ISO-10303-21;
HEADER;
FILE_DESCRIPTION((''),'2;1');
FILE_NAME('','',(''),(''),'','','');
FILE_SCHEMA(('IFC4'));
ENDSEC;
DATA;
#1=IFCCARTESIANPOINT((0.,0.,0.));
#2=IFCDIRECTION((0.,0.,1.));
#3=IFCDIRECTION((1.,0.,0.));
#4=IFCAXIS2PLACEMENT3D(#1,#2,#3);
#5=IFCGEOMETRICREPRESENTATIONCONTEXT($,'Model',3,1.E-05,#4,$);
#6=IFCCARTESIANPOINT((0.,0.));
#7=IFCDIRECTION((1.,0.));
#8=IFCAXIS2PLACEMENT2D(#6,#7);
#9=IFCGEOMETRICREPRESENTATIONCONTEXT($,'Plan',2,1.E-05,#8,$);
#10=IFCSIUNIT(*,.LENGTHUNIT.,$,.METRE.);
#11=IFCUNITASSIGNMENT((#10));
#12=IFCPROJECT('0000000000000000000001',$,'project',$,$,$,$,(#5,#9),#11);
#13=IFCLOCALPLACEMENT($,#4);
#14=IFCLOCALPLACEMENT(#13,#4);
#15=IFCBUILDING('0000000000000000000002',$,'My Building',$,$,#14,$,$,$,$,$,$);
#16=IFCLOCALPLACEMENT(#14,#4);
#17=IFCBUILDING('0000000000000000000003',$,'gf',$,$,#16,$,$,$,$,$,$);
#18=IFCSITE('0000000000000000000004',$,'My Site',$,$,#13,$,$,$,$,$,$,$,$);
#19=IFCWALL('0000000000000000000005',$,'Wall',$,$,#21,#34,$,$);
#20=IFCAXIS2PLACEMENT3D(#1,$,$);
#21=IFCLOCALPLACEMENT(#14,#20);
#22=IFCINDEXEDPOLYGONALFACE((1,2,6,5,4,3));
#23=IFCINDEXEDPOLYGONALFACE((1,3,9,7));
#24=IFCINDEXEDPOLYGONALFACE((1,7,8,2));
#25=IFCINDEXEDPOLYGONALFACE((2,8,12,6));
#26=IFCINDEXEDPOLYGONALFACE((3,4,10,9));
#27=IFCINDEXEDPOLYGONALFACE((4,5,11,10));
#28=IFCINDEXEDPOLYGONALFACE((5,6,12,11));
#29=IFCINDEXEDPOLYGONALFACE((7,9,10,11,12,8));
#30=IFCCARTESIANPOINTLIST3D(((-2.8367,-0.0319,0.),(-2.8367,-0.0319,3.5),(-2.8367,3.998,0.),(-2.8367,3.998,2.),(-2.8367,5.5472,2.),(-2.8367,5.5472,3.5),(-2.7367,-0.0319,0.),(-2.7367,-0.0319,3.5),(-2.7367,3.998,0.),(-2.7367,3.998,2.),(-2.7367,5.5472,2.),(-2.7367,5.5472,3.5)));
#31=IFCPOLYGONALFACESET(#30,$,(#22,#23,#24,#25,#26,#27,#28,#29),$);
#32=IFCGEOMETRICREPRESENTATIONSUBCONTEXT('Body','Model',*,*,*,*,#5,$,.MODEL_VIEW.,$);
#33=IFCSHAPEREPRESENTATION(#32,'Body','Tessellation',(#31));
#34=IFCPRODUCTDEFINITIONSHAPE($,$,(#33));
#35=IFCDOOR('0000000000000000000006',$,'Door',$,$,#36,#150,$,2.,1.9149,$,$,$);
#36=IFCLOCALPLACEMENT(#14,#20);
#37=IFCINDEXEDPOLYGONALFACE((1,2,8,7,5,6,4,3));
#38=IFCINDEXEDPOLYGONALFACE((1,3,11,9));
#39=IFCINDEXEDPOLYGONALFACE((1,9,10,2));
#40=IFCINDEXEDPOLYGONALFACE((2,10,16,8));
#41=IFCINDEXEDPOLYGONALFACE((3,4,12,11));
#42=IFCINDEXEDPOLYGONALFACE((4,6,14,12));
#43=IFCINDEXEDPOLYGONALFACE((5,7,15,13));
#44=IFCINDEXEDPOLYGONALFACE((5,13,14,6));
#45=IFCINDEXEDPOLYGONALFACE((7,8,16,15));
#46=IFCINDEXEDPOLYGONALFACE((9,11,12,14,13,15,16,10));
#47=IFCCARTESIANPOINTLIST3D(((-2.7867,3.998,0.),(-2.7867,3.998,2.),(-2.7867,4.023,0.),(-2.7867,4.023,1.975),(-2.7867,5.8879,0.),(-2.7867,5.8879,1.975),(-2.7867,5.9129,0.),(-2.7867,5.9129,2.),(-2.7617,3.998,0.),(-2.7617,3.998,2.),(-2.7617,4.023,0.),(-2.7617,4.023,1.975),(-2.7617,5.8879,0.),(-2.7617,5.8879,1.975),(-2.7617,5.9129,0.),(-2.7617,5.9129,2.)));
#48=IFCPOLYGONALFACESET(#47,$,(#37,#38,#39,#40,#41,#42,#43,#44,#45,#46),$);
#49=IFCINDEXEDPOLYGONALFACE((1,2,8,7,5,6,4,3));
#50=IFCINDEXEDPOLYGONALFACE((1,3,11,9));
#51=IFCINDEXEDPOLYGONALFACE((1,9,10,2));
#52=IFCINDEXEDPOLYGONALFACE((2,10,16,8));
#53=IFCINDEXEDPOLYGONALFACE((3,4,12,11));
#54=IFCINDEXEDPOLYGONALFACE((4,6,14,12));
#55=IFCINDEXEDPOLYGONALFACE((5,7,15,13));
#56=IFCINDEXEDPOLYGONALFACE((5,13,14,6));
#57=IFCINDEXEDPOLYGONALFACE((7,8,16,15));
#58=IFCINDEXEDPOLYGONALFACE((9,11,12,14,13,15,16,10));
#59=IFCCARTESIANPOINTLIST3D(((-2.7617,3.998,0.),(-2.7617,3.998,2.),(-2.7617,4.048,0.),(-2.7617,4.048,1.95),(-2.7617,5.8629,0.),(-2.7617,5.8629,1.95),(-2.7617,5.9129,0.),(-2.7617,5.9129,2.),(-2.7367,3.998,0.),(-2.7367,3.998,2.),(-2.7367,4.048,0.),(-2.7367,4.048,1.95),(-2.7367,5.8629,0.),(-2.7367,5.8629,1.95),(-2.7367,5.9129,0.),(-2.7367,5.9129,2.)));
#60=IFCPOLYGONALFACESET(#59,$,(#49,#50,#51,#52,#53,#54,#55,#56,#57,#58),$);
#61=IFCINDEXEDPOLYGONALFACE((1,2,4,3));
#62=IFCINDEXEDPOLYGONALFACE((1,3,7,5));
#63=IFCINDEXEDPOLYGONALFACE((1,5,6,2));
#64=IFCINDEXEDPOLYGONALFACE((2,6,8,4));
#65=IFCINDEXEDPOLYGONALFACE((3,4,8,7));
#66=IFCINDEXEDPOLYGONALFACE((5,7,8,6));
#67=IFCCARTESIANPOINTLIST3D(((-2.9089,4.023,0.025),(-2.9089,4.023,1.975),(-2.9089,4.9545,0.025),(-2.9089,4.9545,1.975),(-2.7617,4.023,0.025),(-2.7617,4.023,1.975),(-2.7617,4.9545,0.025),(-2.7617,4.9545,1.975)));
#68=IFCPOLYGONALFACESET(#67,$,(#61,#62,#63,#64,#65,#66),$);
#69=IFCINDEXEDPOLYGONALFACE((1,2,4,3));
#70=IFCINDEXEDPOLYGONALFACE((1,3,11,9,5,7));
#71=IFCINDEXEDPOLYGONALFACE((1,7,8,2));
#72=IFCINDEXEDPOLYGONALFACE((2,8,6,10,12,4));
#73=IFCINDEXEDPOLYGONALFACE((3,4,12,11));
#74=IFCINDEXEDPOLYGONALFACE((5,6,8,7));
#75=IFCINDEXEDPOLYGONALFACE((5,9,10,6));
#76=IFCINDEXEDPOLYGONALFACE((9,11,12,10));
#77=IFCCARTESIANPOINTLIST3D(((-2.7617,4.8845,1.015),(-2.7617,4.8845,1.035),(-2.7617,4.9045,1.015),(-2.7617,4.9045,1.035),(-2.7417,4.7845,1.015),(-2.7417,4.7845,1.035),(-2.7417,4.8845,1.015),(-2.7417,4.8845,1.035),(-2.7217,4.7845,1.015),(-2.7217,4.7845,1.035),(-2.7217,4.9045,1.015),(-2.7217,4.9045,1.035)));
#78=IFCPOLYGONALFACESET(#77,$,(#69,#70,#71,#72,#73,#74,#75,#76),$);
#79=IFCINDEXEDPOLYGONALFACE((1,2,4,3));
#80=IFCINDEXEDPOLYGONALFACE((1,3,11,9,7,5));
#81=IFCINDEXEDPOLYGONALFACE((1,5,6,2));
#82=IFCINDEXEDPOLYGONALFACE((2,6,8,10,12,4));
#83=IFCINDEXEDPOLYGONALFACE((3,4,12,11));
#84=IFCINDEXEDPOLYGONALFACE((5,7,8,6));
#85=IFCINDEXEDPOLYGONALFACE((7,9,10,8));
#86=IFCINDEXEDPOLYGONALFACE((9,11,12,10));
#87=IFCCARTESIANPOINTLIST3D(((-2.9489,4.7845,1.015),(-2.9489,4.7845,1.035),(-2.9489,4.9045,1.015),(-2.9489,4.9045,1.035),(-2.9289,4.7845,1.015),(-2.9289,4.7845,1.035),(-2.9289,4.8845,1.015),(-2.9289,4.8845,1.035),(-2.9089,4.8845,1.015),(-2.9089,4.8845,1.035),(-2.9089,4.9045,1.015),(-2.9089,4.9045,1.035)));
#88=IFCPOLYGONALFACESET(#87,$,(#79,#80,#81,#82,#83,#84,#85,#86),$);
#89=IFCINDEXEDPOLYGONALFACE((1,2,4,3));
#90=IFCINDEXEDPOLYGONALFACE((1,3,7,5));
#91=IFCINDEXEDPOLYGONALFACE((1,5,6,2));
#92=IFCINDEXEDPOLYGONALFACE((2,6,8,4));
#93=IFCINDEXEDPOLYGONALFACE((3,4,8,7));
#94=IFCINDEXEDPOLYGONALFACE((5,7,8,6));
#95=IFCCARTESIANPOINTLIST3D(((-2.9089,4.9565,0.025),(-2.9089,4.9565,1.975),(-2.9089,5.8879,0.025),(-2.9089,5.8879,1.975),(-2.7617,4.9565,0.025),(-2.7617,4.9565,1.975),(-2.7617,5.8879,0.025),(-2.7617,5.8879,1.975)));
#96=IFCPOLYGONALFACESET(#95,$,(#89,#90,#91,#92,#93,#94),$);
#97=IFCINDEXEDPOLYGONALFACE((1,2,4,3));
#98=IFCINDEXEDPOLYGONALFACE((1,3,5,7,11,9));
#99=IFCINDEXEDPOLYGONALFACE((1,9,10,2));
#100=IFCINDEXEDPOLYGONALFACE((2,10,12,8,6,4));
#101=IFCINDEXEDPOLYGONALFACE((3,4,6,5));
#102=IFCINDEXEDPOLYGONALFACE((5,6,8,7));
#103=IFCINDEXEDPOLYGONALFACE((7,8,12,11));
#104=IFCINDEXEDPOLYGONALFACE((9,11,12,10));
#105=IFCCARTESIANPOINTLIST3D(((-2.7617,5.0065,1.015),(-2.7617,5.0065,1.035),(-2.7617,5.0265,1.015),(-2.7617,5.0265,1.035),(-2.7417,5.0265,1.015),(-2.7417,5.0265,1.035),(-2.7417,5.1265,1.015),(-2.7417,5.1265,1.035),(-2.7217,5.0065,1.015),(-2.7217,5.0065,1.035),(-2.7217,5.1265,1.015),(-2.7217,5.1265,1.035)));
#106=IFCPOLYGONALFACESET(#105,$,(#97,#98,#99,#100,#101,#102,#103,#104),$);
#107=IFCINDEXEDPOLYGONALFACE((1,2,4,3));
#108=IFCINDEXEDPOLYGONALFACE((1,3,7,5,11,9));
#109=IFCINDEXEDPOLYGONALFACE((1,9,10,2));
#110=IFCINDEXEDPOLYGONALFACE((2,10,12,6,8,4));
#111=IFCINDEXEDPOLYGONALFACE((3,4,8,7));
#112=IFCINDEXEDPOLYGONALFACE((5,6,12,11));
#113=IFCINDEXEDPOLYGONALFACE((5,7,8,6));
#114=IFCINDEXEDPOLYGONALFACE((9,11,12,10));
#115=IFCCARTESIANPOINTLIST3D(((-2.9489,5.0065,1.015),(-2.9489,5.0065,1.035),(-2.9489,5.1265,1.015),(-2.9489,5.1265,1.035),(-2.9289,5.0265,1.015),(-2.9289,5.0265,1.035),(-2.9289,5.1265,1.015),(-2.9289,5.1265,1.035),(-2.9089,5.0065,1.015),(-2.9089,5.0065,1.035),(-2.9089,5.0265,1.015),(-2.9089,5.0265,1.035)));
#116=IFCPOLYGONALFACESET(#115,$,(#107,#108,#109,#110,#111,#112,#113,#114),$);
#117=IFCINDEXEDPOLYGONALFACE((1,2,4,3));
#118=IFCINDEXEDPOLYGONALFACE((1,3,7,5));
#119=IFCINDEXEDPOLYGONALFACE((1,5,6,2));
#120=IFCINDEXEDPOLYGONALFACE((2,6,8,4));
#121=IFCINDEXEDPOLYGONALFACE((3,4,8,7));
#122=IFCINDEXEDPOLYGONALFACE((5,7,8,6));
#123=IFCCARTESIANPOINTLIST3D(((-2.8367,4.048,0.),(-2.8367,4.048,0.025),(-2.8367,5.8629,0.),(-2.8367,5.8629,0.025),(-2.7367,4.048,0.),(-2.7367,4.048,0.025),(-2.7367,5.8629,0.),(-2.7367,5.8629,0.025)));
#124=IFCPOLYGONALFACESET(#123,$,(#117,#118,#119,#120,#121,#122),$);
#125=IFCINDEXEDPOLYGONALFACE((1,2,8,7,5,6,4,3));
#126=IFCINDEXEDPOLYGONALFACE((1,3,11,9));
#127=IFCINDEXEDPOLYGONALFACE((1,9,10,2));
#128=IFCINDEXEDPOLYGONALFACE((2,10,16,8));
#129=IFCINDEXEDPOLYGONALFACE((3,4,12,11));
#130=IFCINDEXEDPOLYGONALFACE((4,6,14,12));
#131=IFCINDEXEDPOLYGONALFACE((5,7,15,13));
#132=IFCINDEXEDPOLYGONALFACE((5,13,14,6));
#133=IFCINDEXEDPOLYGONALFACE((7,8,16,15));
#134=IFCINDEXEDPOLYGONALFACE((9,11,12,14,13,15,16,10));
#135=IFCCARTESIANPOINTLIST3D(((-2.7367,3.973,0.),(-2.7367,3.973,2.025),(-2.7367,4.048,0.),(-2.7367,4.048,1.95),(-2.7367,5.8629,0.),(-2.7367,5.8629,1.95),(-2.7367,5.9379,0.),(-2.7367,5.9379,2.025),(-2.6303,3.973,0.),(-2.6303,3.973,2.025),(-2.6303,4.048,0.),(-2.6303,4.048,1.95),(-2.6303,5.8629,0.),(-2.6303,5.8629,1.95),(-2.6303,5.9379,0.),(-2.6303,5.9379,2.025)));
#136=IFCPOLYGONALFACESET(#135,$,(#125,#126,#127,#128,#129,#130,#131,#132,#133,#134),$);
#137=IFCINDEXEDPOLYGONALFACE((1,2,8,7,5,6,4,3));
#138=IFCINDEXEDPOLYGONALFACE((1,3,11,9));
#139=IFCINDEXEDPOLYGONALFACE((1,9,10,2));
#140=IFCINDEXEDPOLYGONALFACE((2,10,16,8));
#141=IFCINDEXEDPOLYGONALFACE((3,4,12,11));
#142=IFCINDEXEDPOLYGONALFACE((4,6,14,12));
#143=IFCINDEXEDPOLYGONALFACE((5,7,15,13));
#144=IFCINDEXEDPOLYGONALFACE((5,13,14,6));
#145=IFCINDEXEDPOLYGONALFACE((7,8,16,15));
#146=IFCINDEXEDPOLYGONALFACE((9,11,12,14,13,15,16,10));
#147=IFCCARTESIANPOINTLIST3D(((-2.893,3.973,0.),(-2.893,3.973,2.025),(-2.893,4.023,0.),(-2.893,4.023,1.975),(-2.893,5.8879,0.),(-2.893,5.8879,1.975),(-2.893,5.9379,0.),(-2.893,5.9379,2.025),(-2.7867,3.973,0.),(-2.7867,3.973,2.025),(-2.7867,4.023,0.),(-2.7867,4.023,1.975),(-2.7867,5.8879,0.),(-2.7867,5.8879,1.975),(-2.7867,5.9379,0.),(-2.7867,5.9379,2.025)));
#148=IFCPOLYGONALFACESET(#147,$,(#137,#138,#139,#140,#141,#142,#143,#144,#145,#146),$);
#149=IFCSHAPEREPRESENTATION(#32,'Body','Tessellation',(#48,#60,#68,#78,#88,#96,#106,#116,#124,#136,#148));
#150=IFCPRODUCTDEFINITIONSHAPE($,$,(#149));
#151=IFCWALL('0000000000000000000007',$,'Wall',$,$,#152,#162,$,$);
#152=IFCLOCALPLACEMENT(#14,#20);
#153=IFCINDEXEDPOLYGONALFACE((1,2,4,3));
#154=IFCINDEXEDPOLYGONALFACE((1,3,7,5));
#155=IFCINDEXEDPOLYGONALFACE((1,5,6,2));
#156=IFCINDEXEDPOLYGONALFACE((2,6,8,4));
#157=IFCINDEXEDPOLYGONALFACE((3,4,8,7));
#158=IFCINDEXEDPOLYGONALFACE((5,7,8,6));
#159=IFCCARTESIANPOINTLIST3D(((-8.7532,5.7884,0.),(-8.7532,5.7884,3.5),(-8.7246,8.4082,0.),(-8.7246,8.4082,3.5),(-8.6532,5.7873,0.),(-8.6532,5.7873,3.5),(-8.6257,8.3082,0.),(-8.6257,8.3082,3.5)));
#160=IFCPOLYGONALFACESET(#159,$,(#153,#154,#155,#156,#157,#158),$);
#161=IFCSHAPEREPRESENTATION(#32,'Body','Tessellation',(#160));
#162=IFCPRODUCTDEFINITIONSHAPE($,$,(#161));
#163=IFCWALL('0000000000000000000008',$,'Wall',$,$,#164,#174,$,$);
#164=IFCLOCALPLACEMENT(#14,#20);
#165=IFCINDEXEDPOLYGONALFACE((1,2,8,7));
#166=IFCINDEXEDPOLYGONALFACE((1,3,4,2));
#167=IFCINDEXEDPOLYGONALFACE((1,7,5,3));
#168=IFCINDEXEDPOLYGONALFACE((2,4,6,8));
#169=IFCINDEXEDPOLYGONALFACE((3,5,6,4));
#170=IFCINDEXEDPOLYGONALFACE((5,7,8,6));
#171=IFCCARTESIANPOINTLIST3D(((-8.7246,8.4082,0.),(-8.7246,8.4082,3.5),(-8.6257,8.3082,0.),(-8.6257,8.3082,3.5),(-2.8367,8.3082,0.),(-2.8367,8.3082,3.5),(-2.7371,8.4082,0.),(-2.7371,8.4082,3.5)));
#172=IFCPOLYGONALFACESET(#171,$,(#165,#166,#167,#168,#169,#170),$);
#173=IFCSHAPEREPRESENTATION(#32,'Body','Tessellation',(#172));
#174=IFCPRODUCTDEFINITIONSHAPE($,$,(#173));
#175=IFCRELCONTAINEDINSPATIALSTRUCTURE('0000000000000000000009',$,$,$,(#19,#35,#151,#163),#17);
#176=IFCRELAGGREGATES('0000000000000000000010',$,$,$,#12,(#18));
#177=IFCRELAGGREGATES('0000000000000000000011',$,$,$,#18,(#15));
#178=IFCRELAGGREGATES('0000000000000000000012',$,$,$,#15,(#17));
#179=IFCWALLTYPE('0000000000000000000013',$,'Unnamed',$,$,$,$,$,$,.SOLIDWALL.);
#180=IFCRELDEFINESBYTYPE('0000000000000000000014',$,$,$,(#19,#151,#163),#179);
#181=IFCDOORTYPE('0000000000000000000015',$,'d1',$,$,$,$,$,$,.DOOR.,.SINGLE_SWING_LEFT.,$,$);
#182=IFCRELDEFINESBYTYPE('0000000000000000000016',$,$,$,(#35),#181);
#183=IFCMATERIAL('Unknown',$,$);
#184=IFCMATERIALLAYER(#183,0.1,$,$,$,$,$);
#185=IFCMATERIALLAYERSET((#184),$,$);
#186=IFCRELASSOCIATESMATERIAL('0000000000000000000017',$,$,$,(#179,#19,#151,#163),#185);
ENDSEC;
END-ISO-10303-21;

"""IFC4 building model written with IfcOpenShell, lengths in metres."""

from ifc_helpers import new_model, entity, si_unit, frame, origin_with_axes, origin_2d_with_axis, place, context, subcontext, project, spatial, line, indexed_curve, outline, extrude, shape, source, transform, mapped, material, layer, layer_set, layer_usage, type_object, type_shapes, element, fill, save


model = new_model("IFC4")

# Units and contexts
model_context = context("Model", 3, precision=1e-05, world=origin_with_axes())
plan_context = context("Plan", 2, precision=1e-05, world=origin_2d_with_axis())
body_context_1 = subcontext(model_context, "Body", "Model", "MODEL_VIEW")
body_context_2 = subcontext(plan_context, "Body", "Plan", "PLAN_VIEW")
ifc_project = project(units=[si_unit("LENGTHUNIT", "METRE")], contexts=[model_context, plan_context])

# Site, buildings
site_placement = place(None, origin_with_axes())
site = spatial("IfcSite", under=ifc_project, at=site_placement, Name="My Site")
building_1_placement = place(site_placement, origin_with_axes())
building_1 = spatial("IfcBuilding", under=site, at=building_1_placement, Name="My Building")
building_2_placement = place(building_1_placement, origin_with_axes())
building_2 = spatial("IfcBuilding", under=building_1, at=building_2_placement, Name="gf")

# Shared definitions
ifc_material = material(Name="Unknown")

# Shared definitions
ifc_layer_1 = layer(ifc_material, 0.1)
ifc_layer_set_1 = layer_set([ifc_layer_1])
wall_type = type_object("IfcWallType", Name="Unnamed", PredefinedType="SOLIDWALL", material=ifc_layer_set_1)

# Wall, opening, door
ifc_layer_usage_1 = layer_usage(ifc_layer_set_1, "AXIS2", "POSITIVE", 0.0)
wall_1_placement = place(building_2_placement, frame((-2.8367, 5.5472, 0.0), z_axis=(0.0, 0.0, 1.0), x_axis=(0.0, -1.0, 0.0)))
wall_1 = element("IfcWall", 1, at=wall_1_placement, inside=building_2, type_object=wall_type, material=ifc_layer_usage_1, Name="Wall", context=body_context_1, shape_type="SweptSolid", body=[
    extrude(outline(indexed_curve([(0.0, 0.0), (0.0, 0.1), (5.5791, 0.1), (5.5791, 0.0)], segments=[line(1, 2, 3, 4, 1)])), origin_with_axes(), (0.0, 0.0, 1.0), 3.5),
])
shared_shape_1 = source(origin_with_axes(), body_context_1, "Body", "SweptSolid", [
    extrude(outline(indexed_curve([(0.0, 0.0), (1.9149, 0.0), (1.9149, 2.0), (0.0, 2.0)], segments=[line(1, 2, 3, 4, 1)])), frame((0.0, -0.6, 0.0), z_axis=(0.0, -1.0, 0.0), x_axis=(1.0, 0.0, 0.0)), (0.0, 0.0, -1.0), 1.2),
])
opening_1_placement = place(wall_1_placement, frame((1.5493, 0.1, 0.0), z_axis=(0.0, 0.0, 1.0), x_axis=(-1.0, 0.0, 0.0)))
opening_1 = element("IfcOpeningElement", 2, at=opening_1_placement, cuts=wall_1, PredefinedType="OPENING", context=body_context_1, shape_type="MappedRepresentation", body=[
    mapped(shared_shape_1, transform((0.0, 0.0, 0.0), x_axis=(1.0, 0.0, 0.0), y_axis=(0.0, 1.0, 0.0), z_axis=(0.0, 0.0, 1.0), scale=1.0)),
])
door_type = type_object("IfcDoorType", Name="d1", OperationType="SINGLE_SWING_LEFT", PredefinedType="DOOR")
shared_shape_2 = source(origin_with_axes(), body_context_1, "Body", "SweptSolid", [
    extrude(outline(indexed_curve([(0.0, 0.0), (0.0, 2.0), (1.9149, 2.0), (1.9149, 0.0), (1.8899, 0.0), (1.8899, 1.975), (0.025, 1.975), (0.025, 0.0)], segments=[line(1, 2, 3, 4, 5, 6, 7, 8, 1)])), frame((0.0, 0.025, 0.0), z_axis=(0.0, -1.0, 0.0), x_axis=(1.0, 0.0, 0.0)), (0.0, 0.0, -1.0), 0.025),
    extrude(outline(indexed_curve([(0.0, 0.0), (0.0, 2.0), (1.9149, 2.0), (1.9149, 0.0), (1.8649, 0.0), (1.8649, 1.95), (0.05, 1.95), (0.05, 0.0)], segments=[line(1, 2, 3, 4, 5, 6, 7, 8, 1)])), frame((0.0, 0.0, 0.0), z_axis=(0.0, -1.0, 0.0), x_axis=(1.0, 0.0, 0.0)), (0.0, 0.0, -1.0), 0.025),
    extrude(outline(indexed_curve([(0.0, 0.0), (0.9315, 0.0), (0.9315, 0.1472), (0.0, 0.1472)], segments=[line(1, 2, 3, 4, 1)])), frame((0.025, 0.025, 0.025), z_axis=(0.0, 0.0, 1.0), x_axis=(1.0, 0.0, 0.0)), (0.0, 0.0, 1.0), 1.95),
    extrude(outline(indexed_curve([(0.0, 0.0), (0.0, -0.04), (-0.12, -0.04), (-0.12, -0.02), (-0.02, -0.02), (-0.02, 0.0)], segments=[line(1, 2, 3, 4, 5, 6, 1)])), frame((0.9065, 0.025, 1.015), z_axis=(0.0, 0.0, 1.0), x_axis=(1.0, 0.0, 0.0)), (0.0, 0.0, 1.0), 0.02),
    extrude(outline(indexed_curve([(0.0, 0.0), (0.0, 0.04), (-0.12, 0.04), (-0.12, 0.02), (-0.02, 0.02), (-0.02, 0.0)], segments=[line(1, 2, 3, 4, 5, 6, 1)])), frame((0.9065, 0.1722, 1.015), z_axis=(0.0, 0.0, 1.0), x_axis=(1.0, 0.0, 0.0)), (0.0, 0.0, 1.0), 0.02),
    extrude(outline(indexed_curve([(0.0, 0.0), (-0.9315, 0.0), (-0.9315, 0.1472), (0.0, 0.1472)], segments=[line(1, 2, 3, 4, 1)])), frame((1.8899, 0.025, 0.025), z_axis=(0.0, 0.0, 1.0), x_axis=(1.0, 0.0, 0.0)), (0.0, 0.0, 1.0), 1.95),
    extrude(outline(indexed_curve([(0.0, 0.0), (0.0, -0.04), (0.12, -0.04), (0.12, -0.02), (0.02, -0.02), (0.02, 0.0)], segments=[line(1, 2, 3, 4, 5, 6, 1)])), frame((1.0085, 0.025, 1.015), z_axis=(0.0, 0.0, 1.0), x_axis=(1.0, 0.0, 0.0)), (0.0, 0.0, 1.0), 0.02),
    extrude(outline(indexed_curve([(0.0, 0.0), (0.0, 0.04), (0.12, 0.04), (0.12, 0.02), (0.02, 0.02), (0.02, 0.0)], segments=[line(1, 2, 3, 4, 5, 6, 1)])), frame((1.0085, 0.1722, 1.015), z_axis=(0.0, 0.0, 1.0), x_axis=(1.0, 0.0, 0.0)), (0.0, 0.0, 1.0), 0.02),
    extrude(outline(indexed_curve([(0.0, 0.0), (1.8149, 0.0), (1.8149, 0.1), (0.0, 0.1)], segments=[line(1, 2, 3, 4, 1)])), frame((0.05, 0.0, 0.0), z_axis=(0.0, 0.0, 1.0), x_axis=(1.0, 0.0, 0.0)), (0.0, 0.0, 1.0), 0.025),
    extrude(outline(indexed_curve([(0.0, 0.0), (0.0, 2.025), (1.9649, 2.025), (1.9649, 0.0), (1.8899, 0.0), (1.8899, 1.95), (0.075, 1.95), (0.075, 0.0)], segments=[line(1, 2, 3, 4, 5, 6, 7, 8, 1)])), frame((-0.025, -0.1064, 0.0), z_axis=(0.0, -1.0, 0.0), x_axis=(1.0, 0.0, 0.0)), (0.0, 0.0, -1.0), 0.1064),
    extrude(outline(indexed_curve([(0.0, 0.0), (0.0, 2.025), (1.9649, 2.025), (1.9649, 0.0), (1.9149, 0.0), (1.9149, 1.975), (0.05, 1.975), (0.05, 0.0)], segments=[line(1, 2, 3, 4, 5, 6, 7, 8, 1)])), frame((-0.025, 0.05, 0.0), z_axis=(0.0, -1.0, 0.0), x_axis=(1.0, 0.0, 0.0)), (0.0, 0.0, -1.0), 0.1064),
])
shared_shape_3 = source(origin_with_axes(), body_context_2, "Body", "Curve2D", [
    entity("IfcIndexedPolyCurve", entity("IfcCartesianPointList2D", [[0.0, 0.0], [0.0, 0.05], [0.025, 0.05], [0.025, 0.025], [0.05, 0.025], [0.05, 0.0]]), [entity("IfcLineIndex", [1, 2, 3, 4, 5, 6, 1])]),
    entity("IfcIndexedPolyCurve", entity("IfcCartesianPointList2D", [[1.9149, 0.0], [1.9149, 0.05], [1.8899, 0.05], [1.8899, 0.025], [1.8649, 0.025], [1.8649, 0.0]]), [entity("IfcLineIndex", [1, 2, 3, 4, 5, 6, 1])]),
    entity("IfcTrimmedCurve", entity("IfcEllipse", entity("IfcAxis2Placement2D", entity("IfcCartesianPoint", [0.1722, 0.05]), entity("IfcDirection", [1.0, 0.0])), 0.7853, 0.9325), [entity("IfcCartesianPoint", [0.9575, 0.05])], [entity("IfcCartesianPoint", [0.1722, 0.9825])], True, "CARTESIAN"),
    entity("IfcIndexedPolyCurve", entity("IfcCartesianPointList2D", [[0.025, 0.05], [0.1722, 0.05], [0.1722, 0.9825], [0.025, 0.9825]]), [entity("IfcLineIndex", [1, 2, 3, 4, 1])]),
    entity("IfcTrimmedCurve", entity("IfcEllipse", entity("IfcAxis2Placement2D", entity("IfcCartesianPoint", [1.7427, 0.05]), entity("IfcDirection", [1.0, 0.0])), 0.7853, 0.9325), [entity("IfcCartesianPoint", [1.7427, 0.9825])], [entity("IfcCartesianPoint", [0.9575, 0.05])], True, "CARTESIAN"),
    entity("IfcIndexedPolyCurve", entity("IfcCartesianPointList2D", [[1.8899, 0.05], [1.7427, 0.05], [1.7427, 0.9825], [1.8899, 0.9825]]), [entity("IfcLineIndex", [1, 2, 3, 4, 1])]),
])
type_shapes(door_type, [shared_shape_2, shared_shape_3])
door_1_placement = place(opening_1_placement, frame((0.0, 0.0, 0.0), z_axis=(0.0, 0.0, 1.0), x_axis=(1.0, 0.0, 0.0)))
door_1 = element("IfcDoor", 3, at=door_1_placement, inside=building_2, type_object=door_type, Name="Door", OverallHeight=2.0, OverallWidth=1.9149, shapes=[
    shape(body_context_1, "Body", "MappedRepresentation", [mapped(shared_shape_2, transform((0.0, 0.0, 0.0), x_axis=(1.0, 0.0, 0.0), y_axis=(0.0, 1.0, 0.0), z_axis=(0.0, 0.0, 1.0), scale=1.0))]),
    shape(body_context_2, "Body", "MappedRepresentation", [mapped(shared_shape_3, transform((0.0, 0.0, 0.0), x_axis=(1.0, 0.0, 0.0), y_axis=(0.0, 1.0, 0.0), z_axis=(0.0, 0.0, 1.0), scale=1.0))]),
])
fill(opening_1, door_1)

# Walls
ifc_layer_usage_2 = layer_usage(ifc_layer_set_1, "AXIS2", "POSITIVE", 0.0)
wall_2_placement = place(building_2_placement, frame((-8.6532, 5.7873, 0.0), z_axis=(0.0, 0.0, 1.0), x_axis=(0.010914, 0.99994, 0.0)))
element("IfcWall", 4, at=wall_2_placement, inside=building_2, type_object=wall_type, material=ifc_layer_usage_2, Name="Wall", context=body_context_1, shape_type="SweptSolid", body=[
    extrude(outline(indexed_curve([(0.0, 0.0), (0.0, 0.1), (2.6199, 0.1), (2.521, 0.0)], segments=[line(1, 2, 3, 4, 1)])), origin_with_axes(), (0.0, 0.0, 1.0), 3.5),
])
ifc_layer_usage_3 = layer_usage(ifc_layer_set_1, "AXIS2", "POSITIVE", 0.0)
wall_3_placement = place(building_2_placement, frame((-8.6257, 8.3082, 0.0), z_axis=(0.0, 0.0, 1.0), x_axis=(1.0, 0.0, 0.0)))
element("IfcWall", 5, at=wall_3_placement, inside=building_2, type_object=wall_type, material=ifc_layer_usage_3, Name="Wall", context=body_context_1, shape_type="SweptSolid", body=[
    extrude(outline(indexed_curve([(0.0, 0.0), (-0.0989, 0.1), (5.8885, 0.1), (5.789, 0.0)], segments=[line(1, 2, 3, 4, 1)])), origin_with_axes(), (0.0, 0.0, 1.0), 3.5),
])

save(model, "model.ifc")
